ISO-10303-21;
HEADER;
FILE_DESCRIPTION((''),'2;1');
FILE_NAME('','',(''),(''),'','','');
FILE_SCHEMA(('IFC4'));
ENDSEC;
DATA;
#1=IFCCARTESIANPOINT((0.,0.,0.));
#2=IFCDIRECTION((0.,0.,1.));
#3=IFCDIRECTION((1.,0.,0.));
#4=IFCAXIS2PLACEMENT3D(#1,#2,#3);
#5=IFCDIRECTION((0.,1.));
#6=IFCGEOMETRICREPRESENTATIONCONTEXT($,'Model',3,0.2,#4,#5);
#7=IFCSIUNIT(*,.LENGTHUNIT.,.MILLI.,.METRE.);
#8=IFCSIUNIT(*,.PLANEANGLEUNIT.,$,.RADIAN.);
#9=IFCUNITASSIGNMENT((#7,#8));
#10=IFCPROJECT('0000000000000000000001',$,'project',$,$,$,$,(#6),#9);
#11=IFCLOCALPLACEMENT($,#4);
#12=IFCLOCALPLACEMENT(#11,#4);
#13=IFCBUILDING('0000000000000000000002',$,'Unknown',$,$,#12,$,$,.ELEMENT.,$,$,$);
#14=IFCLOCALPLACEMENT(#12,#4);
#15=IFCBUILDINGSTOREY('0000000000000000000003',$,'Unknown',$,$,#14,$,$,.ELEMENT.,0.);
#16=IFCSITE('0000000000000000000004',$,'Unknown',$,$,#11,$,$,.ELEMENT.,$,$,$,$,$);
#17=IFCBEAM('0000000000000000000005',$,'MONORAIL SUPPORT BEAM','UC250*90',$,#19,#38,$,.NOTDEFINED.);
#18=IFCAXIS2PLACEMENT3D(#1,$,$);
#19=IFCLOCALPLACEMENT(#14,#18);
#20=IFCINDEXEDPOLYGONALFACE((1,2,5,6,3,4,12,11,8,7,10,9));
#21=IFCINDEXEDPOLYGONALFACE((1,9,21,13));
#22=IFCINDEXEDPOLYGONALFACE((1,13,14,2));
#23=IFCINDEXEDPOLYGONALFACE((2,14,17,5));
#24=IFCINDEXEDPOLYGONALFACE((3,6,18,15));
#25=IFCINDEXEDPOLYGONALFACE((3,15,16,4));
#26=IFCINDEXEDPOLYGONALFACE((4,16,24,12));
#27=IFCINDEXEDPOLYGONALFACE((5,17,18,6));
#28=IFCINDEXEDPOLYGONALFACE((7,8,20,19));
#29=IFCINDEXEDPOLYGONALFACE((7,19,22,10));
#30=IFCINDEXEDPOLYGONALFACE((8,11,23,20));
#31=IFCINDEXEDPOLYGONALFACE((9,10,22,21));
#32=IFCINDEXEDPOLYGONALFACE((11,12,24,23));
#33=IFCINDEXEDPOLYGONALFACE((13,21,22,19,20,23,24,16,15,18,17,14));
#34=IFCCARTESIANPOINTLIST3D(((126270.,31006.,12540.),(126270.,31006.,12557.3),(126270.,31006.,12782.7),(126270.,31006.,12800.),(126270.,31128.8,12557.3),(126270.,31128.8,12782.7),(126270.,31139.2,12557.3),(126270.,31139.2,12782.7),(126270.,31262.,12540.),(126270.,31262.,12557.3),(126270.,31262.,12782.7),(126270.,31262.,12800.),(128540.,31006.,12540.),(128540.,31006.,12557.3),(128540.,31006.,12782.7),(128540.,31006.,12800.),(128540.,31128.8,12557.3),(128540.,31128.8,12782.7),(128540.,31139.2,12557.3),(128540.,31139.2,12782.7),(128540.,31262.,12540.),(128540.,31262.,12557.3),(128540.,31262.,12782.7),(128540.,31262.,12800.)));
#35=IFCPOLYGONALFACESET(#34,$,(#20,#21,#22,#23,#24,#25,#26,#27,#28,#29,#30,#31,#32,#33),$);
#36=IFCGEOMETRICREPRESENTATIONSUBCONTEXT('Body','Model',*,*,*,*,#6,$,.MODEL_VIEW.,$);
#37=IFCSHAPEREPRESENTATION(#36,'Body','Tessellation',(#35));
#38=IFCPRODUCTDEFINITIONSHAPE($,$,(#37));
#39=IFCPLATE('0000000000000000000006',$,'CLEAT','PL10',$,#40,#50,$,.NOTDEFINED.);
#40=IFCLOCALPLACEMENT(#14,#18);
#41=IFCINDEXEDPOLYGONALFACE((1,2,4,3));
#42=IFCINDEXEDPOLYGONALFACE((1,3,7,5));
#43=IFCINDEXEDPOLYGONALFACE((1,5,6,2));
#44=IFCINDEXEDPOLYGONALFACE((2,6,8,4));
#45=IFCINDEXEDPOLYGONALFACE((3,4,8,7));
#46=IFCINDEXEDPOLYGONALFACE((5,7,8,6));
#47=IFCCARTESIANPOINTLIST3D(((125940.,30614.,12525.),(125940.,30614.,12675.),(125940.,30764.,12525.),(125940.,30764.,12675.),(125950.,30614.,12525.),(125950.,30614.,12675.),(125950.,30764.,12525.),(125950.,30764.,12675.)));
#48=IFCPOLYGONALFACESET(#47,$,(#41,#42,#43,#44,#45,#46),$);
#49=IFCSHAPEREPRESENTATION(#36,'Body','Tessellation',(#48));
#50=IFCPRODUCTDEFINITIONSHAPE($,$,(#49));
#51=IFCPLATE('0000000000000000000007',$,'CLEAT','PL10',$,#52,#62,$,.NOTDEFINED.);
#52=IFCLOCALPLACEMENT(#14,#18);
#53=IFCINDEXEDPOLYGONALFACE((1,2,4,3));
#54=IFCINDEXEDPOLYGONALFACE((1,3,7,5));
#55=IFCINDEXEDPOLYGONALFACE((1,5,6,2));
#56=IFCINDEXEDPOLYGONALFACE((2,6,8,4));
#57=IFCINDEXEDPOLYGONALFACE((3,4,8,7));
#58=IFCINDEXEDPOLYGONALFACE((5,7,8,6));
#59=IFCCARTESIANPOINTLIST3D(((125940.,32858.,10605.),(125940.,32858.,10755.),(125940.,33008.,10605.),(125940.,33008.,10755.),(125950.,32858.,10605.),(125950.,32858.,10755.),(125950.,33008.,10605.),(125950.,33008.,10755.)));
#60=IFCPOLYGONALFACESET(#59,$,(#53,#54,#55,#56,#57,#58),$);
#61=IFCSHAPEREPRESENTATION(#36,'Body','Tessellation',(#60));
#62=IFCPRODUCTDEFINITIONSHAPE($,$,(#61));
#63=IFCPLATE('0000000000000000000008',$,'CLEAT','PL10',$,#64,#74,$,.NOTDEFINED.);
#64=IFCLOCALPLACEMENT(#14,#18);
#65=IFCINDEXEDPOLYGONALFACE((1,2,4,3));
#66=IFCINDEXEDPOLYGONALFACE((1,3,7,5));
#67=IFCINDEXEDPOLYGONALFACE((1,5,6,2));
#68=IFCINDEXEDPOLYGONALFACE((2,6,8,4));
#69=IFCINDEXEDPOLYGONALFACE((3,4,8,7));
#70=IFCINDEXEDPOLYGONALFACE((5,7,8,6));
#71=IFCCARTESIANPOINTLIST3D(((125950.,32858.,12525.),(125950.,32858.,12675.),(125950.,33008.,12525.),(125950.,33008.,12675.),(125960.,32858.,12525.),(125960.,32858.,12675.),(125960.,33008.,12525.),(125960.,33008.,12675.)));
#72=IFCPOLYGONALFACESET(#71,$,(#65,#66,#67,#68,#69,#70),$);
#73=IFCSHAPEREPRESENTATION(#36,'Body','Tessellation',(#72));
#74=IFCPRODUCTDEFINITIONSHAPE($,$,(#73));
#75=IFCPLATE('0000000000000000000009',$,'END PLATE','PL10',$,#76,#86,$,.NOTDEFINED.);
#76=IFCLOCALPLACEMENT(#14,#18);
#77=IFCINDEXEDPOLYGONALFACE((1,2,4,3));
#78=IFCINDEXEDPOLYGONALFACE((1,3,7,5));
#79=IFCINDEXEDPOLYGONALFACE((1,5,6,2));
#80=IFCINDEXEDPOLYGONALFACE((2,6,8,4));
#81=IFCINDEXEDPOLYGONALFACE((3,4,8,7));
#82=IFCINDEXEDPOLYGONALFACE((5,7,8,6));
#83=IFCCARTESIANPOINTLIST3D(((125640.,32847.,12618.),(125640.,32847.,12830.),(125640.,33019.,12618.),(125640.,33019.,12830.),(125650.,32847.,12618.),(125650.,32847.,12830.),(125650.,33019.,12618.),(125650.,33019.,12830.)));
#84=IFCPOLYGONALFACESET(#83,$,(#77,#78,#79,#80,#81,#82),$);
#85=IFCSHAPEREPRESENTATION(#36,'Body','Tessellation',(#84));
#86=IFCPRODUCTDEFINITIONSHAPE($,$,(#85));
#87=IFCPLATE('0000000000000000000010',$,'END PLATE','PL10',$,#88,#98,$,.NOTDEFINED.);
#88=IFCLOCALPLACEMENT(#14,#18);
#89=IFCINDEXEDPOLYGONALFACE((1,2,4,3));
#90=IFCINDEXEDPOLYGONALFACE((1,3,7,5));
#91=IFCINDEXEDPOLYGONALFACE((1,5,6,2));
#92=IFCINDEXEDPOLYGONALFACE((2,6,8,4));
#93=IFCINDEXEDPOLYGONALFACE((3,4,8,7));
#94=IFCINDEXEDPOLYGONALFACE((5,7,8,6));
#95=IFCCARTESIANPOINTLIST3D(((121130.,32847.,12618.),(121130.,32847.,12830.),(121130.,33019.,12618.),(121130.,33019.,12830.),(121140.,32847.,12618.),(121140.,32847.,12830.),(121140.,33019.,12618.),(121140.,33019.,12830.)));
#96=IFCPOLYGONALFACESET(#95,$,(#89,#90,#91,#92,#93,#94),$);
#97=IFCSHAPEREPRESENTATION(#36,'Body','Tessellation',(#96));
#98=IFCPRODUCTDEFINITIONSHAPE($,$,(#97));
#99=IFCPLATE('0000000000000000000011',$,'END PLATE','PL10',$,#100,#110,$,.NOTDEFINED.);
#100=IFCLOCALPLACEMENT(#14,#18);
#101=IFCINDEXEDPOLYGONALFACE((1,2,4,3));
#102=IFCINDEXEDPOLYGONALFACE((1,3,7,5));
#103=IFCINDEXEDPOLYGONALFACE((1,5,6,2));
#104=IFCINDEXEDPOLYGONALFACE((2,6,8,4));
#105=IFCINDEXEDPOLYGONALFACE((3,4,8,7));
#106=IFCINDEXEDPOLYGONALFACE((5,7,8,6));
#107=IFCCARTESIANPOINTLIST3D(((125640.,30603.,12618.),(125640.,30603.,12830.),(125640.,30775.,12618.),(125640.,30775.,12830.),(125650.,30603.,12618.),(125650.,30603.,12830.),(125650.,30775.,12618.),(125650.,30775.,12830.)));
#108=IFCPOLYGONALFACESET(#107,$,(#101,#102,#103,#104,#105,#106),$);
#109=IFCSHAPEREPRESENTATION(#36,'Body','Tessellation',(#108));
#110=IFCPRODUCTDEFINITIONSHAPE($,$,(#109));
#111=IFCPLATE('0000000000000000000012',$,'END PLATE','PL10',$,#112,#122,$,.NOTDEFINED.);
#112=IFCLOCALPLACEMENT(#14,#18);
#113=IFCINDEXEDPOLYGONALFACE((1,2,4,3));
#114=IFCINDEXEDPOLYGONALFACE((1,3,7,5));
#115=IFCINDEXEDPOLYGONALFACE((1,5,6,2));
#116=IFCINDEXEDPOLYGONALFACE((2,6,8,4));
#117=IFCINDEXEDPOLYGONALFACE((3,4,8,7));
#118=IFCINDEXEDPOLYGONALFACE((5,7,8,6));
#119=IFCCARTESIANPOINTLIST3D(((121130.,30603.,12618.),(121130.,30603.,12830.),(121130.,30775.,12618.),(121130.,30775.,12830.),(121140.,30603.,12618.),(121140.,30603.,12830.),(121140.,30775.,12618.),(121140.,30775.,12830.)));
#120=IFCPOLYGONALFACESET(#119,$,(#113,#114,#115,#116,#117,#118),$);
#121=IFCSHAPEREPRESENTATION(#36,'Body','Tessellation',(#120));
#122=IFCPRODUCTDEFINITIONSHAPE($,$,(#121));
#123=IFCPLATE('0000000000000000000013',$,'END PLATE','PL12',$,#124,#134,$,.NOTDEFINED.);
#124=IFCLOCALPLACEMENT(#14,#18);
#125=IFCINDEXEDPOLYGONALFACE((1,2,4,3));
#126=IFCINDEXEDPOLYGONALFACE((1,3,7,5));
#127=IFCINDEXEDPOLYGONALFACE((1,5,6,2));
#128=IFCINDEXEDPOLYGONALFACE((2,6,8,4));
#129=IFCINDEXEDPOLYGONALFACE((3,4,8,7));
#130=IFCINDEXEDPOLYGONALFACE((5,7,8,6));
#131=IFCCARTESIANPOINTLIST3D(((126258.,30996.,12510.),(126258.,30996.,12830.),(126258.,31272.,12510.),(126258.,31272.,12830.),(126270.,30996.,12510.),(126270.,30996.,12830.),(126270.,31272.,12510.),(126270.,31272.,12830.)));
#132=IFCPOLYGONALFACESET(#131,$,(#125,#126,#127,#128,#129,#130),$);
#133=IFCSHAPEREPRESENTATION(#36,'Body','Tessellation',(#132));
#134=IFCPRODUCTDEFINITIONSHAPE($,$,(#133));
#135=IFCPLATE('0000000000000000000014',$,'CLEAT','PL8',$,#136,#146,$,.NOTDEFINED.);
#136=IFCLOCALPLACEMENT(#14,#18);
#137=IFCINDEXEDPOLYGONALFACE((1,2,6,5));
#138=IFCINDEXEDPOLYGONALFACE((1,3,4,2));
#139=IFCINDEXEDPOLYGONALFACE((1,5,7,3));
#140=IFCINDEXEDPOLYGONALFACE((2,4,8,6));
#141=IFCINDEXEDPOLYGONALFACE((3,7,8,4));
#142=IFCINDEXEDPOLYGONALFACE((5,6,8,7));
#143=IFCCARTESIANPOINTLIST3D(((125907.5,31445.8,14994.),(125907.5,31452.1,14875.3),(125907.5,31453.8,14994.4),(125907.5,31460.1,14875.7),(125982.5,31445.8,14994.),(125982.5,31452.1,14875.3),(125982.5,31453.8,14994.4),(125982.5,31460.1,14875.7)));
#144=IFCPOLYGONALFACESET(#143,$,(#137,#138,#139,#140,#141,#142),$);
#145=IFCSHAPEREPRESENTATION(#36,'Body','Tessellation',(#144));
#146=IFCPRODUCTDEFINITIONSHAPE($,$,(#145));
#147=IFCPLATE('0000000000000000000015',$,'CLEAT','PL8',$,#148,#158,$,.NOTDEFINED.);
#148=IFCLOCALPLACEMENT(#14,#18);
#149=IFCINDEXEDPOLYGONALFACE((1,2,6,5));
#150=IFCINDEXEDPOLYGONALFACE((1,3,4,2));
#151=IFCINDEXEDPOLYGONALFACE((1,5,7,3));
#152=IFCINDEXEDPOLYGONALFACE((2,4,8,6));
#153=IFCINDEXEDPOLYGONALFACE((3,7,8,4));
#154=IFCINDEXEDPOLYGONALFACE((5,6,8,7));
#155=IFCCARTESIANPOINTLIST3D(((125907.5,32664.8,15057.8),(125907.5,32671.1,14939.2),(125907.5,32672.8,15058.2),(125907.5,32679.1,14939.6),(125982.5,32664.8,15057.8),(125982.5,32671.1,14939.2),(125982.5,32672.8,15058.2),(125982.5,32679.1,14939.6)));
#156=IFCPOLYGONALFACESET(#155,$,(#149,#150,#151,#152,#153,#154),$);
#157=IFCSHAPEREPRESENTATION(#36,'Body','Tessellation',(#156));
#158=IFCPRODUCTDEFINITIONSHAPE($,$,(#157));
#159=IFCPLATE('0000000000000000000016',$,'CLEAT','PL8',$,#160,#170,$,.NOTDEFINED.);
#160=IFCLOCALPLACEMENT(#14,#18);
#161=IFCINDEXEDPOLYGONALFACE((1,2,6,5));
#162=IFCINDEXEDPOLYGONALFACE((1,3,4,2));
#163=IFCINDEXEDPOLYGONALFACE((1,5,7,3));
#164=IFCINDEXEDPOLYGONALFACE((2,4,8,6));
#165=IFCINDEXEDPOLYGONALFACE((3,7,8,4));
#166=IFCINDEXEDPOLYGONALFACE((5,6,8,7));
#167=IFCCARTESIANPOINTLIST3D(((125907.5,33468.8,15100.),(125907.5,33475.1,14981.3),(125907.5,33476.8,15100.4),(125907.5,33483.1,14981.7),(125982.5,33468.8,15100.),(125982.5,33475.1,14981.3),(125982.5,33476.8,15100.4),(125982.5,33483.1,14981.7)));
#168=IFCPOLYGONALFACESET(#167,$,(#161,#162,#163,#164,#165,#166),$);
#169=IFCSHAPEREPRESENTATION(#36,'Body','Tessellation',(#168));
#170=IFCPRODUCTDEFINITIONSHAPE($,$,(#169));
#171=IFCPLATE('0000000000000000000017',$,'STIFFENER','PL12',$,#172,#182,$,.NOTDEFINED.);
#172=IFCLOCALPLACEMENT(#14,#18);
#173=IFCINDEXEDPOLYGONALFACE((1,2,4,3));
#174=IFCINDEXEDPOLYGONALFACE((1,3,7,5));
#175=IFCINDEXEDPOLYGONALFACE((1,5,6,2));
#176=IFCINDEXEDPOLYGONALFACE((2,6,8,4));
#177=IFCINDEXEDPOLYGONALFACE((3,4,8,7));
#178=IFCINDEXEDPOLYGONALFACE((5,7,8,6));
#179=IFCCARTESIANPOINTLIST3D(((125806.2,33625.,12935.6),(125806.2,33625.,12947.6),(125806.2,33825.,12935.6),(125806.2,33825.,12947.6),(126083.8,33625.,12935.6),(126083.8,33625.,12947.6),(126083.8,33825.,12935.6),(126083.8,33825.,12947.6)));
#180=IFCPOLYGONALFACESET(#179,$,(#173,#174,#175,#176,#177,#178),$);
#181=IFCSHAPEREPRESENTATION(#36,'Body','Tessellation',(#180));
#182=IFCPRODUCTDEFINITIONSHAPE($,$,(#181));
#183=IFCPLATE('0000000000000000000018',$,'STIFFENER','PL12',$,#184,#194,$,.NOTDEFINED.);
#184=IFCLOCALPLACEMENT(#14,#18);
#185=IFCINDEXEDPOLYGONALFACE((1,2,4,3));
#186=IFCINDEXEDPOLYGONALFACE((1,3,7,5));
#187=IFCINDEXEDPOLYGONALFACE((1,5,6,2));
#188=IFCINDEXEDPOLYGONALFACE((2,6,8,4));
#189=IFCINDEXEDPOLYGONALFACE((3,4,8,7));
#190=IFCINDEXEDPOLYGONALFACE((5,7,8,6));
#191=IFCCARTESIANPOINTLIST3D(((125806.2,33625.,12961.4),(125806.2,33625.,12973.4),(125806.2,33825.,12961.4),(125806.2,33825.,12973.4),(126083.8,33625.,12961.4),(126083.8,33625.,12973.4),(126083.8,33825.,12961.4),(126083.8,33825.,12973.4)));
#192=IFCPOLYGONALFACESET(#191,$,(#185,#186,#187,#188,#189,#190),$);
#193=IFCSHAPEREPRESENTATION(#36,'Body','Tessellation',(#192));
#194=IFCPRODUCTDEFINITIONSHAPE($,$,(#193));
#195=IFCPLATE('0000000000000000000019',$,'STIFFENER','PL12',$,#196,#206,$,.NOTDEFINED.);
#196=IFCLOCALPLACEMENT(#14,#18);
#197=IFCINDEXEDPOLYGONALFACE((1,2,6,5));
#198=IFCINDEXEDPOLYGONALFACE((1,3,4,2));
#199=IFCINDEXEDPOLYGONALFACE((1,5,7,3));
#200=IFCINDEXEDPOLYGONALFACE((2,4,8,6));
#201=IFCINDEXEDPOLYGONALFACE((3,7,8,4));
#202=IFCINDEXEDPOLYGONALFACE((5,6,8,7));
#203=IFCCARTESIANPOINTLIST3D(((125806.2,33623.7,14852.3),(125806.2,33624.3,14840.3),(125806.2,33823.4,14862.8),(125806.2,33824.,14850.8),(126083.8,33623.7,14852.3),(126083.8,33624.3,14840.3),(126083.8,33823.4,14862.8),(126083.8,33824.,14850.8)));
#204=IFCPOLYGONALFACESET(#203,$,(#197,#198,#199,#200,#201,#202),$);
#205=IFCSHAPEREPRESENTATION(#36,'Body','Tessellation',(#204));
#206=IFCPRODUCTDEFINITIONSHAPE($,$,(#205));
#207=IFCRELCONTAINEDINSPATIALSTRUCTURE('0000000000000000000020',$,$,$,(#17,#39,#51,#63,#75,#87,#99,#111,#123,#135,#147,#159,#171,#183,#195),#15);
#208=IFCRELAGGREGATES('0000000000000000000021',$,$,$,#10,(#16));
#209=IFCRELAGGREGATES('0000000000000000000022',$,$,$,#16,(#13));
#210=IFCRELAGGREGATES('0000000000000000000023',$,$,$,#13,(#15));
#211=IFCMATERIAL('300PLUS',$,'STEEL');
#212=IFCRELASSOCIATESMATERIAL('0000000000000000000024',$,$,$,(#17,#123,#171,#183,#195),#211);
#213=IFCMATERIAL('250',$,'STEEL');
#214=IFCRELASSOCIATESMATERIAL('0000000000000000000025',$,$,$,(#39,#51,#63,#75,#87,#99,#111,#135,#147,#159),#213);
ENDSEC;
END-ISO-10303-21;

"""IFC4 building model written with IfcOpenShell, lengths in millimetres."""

from ifc_helpers import new_model, si_unit, direction, frame, origin_with_axes, place, context, subcontext, project, spatial, line, indexed_curve, outline, extrude, material, element, save


model = new_model("IFC4")

# Units and contexts
model_context = context("Model", 3, precision=0.2, world=origin_with_axes(), true_north=direction((0.0, 1.0)))
body_context = subcontext(model_context, "Body", "Model", "MODEL_VIEW")
ifc_project = project(units=[si_unit("LENGTHUNIT", "METRE", prefix="MILLI"), si_unit("PLANEANGLEUNIT", "RADIAN")], contexts=[model_context])

# Site, building, storey
site_placement = place(None, origin_with_axes())
site = spatial("IfcSite", under=ifc_project, at=site_placement, Name="Unknown", CompositionType="ELEMENT")
building_placement = place(site_placement, origin_with_axes())
building = spatial("IfcBuilding", under=site, at=building_placement, Name="Unknown", CompositionType="ELEMENT")
storey_placement = place(building_placement, origin_with_axes())
storey = spatial("IfcBuildingStorey", under=building, at=storey_placement, Name="Unknown", CompositionType="ELEMENT", Elevation=0.0)

# Beam
ifc_material_1 = material(Name="300PLUS", Category="STEEL")
beam_1_placement = place(storey_placement, frame((126270.0, 31134.0, 12670.0), z_axis=(0.0, -1.0, 0.0), x_axis=(1.0, 0.0, 0.0)))
element("IfcBeam", 1, at=beam_1_placement, inside=storey, material=ifc_material_1, Name="MONORAIL SUPPORT BEAM", Description="UC250*90", PredefinedType="NOTDEFINED", context=body_context, shape_type="SolidModel", body=[
    extrude(outline(indexed_curve([(-128.0, -130.0), (128.0, -130.0), (128.0, -112.7), (5.2, -112.7), (5.2, 112.7), (128.0, 112.7), (128.0, 130.0), (-128.0, 130.0), (-128.0, 112.7), (-5.2, 112.7), (-5.2, -112.7), (-128.0, -112.7)], segments=[line(1, 2, 3, 4, 5, 6, 7, 8, 9, 10, 11, 12, 1)])), frame((0.0, 0.0, 0.0), z_axis=(-1.0, 0.0, 0.0), x_axis=(0.0, 0.0, 1.0)), (0.0, 0.0, -1.0), 2270.0),
])

# Plates
ifc_material_2 = material(Name="250", Category="STEEL")
for number, where, z_axis, x_axis, name in (
    (2, (125945.0, 30764.0, 12525.0), (-1.0, 0.0, 0.0), (0.0, -1.0, 0.0), "CLEAT"),
    (3, (125945.0, 33008.0, 10605.0), (-1.0, 0.0, 0.0), (0.0, -1.0, 0.0), "CLEAT"),
    (4, (125955.0, 32858.0, 12525.0), (1.0, 0.0, 0.0), (0.0, 1.0, 0.0), "CLEAT"),
):
    element("IfcPlate", number, at=place(storey_placement, frame(where, z_axis=z_axis, x_axis=x_axis)), inside=storey, material=ifc_material_2, Name=name, Description="PL10", PredefinedType="NOTDEFINED", context=body_context, shape_type="SolidModel", body=[
        extrude(outline(indexed_curve([(0.0, 0.0), (150.0, 0.0), (150.0, 150.0), (0.0, 150.0)], segments=[line(1, 2, 3, 4, 1)])), frame((0.0, 0.0, 5.0), z_axis=(0.0, 0.0, 1.0), x_axis=(1.0, 0.0, 0.0)), (0.0, 0.0, -1.0), 10.0),
    ])
for number, where, z_axis, x_axis, name in (
    (5, (125645.0, 33019.0, 12618.0), (-1.0, 0.0, 0.0), (0.0, -1.0, 0.0), "END PLATE"),
    (6, (121135.0, 33019.0, 12618.0), (-1.0, 0.0, 0.0), (0.0, -1.0, 0.0), "END PLATE"),
    (7, (125645.0, 30775.0, 12618.0), (-1.0, 0.0, 0.0), (0.0, -1.0, 0.0), "END PLATE"),
    (8, (121135.0, 30775.0, 12618.0), (-1.0, 0.0, 0.0), (0.0, -1.0, 0.0), "END PLATE"),
):
    element("IfcPlate", number, at=place(storey_placement, frame(where, z_axis=z_axis, x_axis=x_axis)), inside=storey, material=ifc_material_2, Name=name, Description="PL10", PredefinedType="NOTDEFINED", context=body_context, shape_type="SolidModel", body=[
        extrude(outline(indexed_curve([(0.0, 0.0), (172.0, 0.0), (172.0, 212.0), (0.0, 212.0)], segments=[line(1, 2, 3, 4, 1)])), frame((0.0, 0.0, 5.0), z_axis=(0.0, 0.0, 1.0), x_axis=(1.0, 0.0, 0.0)), (0.0, 0.0, -1.0), 10.0),
    ])
plate_1_placement = place(storey_placement, frame((126264.0, 31272.0, 12510.0), z_axis=(-1.0, 0.0, 0.0), x_axis=(0.0, -1.0, 0.0)))
element("IfcPlate", 9, at=plate_1_placement, inside=storey, material=ifc_material_1, Name="END PLATE", Description="PL12", PredefinedType="NOTDEFINED", context=body_context, shape_type="SolidModel", body=[
    extrude(outline(indexed_curve([(0.0, 0.0), (276.0, 0.0), (276.0, 320.0), (0.0, 320.0)], segments=[line(1, 2, 3, 4, 1)])), frame((0.0, 0.0, 6.0), z_axis=(0.0, 0.0, 1.0), x_axis=(1.0, 0.0, 0.0)), (0.0, 0.0, -1.0), 12.0),
])
plate_2_placement = place(storey_placement, frame((125907.5, 31449.8, 14994.2), z_axis=(0.0, 0.998594, 0.053), x_axis=(1.0, 0.0, 0.0)))
element("IfcPlate", 10, at=plate_2_placement, inside=storey, material=ifc_material_2, Name="CLEAT", Description="PL8", PredefinedType="NOTDEFINED", context=body_context, shape_type="SolidModel", body=[
    extrude(outline(indexed_curve([(0.0, 0.0), (75.0, 0.0), (75.0, 118.9), (0.0, 118.9)], segments=[line(1, 2, 3, 4, 1)])), frame((0.0, 0.0, 4.0), z_axis=(0.0, 0.0, 1.0), x_axis=(1.0, 0.0, 0.0)), (0.0, 0.0, -1.0), 8.0),
])
plate_3_placement = place(storey_placement, frame((125907.5, 32668.8, 15058.0), z_axis=(0.0, 0.998592, 0.053045), x_axis=(1.0, 0.0, 0.0)))
element("IfcPlate", 11, at=plate_3_placement, inside=storey, material=ifc_material_2, Name="CLEAT", Description="PL8", PredefinedType="NOTDEFINED", context=body_context, shape_type="SolidModel", body=[
    extrude(outline(indexed_curve([(0.0, 0.0), (75.0, 0.0), (75.0, 118.8), (0.0, 118.8)], segments=[line(1, 2, 3, 4, 1)])), frame((0.0, 0.0, 4.0), z_axis=(0.0, 0.0, 1.0), x_axis=(1.0, 0.0, 0.0)), (0.0, 0.0, -1.0), 8.0),
])
plate_4_placement = place(storey_placement, frame((125907.5, 33472.8, 15100.2), z_axis=(0.0, 0.998594, 0.053), x_axis=(1.0, 0.0, 0.0)))
element("IfcPlate", 12, at=plate_4_placement, inside=storey, material=ifc_material_2, Name="CLEAT", Description="PL8", PredefinedType="NOTDEFINED", context=body_context, shape_type="SolidModel", body=[
    extrude(outline(indexed_curve([(0.0, 0.0), (75.0, 0.0), (75.0, 118.9), (0.0, 118.9)], segments=[line(1, 2, 3, 4, 1)])), frame((0.0, 0.0, 4.0), z_axis=(0.0, 0.0, 1.0), x_axis=(1.0, 0.0, 0.0)), (0.0, 0.0, -1.0), 8.0),
])
for number, where, z_axis, x_axis, name in (
    (13, (126083.8, 33625.0, 12941.6), (0.0, 0.0, 1.0), (0.0, 1.0, 0.0), "STIFFENER"),
    (14, (126083.8, 33625.0, 12967.4), (0.0, 0.0, 1.0), (0.0, 1.0, 0.0), "STIFFENER"),
):
    element("IfcPlate", number, at=place(storey_placement, frame(where, z_axis=z_axis, x_axis=x_axis)), inside=storey, material=ifc_material_1, Name=name, Description="PL12", PredefinedType="NOTDEFINED", context=body_context, shape_type="SolidModel", body=[
        extrude(outline(indexed_curve([(0.0, 0.0), (200.0, 0.0), (200.0, 277.6), (0.0, 277.6)], segments=[line(1, 2, 3, 4, 1)])), frame((0.0, 0.0, 6.0), z_axis=(0.0, 0.0, 1.0), x_axis=(1.0, 0.0, 0.0)), (0.0, 0.0, -1.0), 12.0),
    ])
plate_5_placement = place(storey_placement, frame((126083.8, 33624.0, 14846.3), z_axis=(0.0, -0.052506, 0.998621), x_axis=(0.0, 0.998621, 0.052506)))
element("IfcPlate", 15, at=plate_5_placement, inside=storey, material=ifc_material_1, Name="STIFFENER", Description="PL12", PredefinedType="NOTDEFINED", context=body_context, shape_type="SolidModel", body=[
    extrude(outline(indexed_curve([(0.0, 0.0), (200.0, 0.0), (200.0, 277.6), (0.0, 277.6)], segments=[line(1, 2, 3, 4, 1)])), frame((0.0, 0.0, 6.0), z_axis=(0.0, 0.0, 1.0), x_axis=(1.0, 0.0, 0.0)), (0.0, 0.0, -1.0), 12.0),
])

save(model, "model.ifc")
